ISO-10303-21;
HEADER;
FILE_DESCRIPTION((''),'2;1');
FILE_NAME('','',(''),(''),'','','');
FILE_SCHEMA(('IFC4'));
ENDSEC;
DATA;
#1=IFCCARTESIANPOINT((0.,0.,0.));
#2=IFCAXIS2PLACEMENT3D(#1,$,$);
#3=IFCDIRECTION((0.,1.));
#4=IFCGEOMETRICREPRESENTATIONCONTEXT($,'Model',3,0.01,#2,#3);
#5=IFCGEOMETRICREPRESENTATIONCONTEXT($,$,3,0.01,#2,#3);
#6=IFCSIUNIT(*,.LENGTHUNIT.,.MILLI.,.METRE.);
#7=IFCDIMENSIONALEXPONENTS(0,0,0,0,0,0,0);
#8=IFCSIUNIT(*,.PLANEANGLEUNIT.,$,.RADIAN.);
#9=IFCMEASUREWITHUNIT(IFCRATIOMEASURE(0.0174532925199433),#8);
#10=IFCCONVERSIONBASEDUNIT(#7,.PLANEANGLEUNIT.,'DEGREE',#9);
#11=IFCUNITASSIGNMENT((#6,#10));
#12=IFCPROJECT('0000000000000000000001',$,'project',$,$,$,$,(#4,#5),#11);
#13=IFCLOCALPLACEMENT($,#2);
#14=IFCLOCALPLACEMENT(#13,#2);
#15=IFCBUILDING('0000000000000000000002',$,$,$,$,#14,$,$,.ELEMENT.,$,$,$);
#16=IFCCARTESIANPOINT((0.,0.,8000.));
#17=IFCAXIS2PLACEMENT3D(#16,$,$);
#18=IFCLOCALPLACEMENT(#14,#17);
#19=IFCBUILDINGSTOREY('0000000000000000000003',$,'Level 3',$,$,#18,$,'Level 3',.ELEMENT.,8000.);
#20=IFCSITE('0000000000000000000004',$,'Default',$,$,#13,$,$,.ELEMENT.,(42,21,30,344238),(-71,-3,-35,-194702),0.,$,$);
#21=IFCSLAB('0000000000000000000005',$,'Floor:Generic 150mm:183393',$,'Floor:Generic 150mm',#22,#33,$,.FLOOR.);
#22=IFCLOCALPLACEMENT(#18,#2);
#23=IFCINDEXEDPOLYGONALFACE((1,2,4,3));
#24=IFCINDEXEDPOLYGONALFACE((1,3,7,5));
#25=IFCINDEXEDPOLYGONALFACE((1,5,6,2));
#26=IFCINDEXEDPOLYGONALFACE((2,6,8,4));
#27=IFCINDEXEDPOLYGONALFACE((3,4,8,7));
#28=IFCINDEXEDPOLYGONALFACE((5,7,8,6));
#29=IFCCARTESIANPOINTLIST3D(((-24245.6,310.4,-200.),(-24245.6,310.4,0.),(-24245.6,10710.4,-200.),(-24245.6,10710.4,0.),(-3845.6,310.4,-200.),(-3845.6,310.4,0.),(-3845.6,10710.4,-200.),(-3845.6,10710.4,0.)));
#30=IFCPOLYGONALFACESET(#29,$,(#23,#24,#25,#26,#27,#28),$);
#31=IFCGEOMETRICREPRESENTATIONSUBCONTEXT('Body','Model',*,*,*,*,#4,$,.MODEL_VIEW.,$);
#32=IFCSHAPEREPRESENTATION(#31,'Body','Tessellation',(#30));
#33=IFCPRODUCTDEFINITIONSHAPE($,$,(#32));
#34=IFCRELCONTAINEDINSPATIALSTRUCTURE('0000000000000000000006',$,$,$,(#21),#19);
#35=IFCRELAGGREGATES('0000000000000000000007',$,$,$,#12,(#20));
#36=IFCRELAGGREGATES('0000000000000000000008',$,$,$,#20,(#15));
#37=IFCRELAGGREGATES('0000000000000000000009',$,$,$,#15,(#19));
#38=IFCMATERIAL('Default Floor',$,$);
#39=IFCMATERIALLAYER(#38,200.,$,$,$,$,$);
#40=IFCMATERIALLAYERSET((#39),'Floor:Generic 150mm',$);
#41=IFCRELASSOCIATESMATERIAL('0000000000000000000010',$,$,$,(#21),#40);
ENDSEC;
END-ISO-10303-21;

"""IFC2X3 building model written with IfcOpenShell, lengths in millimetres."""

from ifc_helpers import new_model, entity, si_unit, converted_unit, direction, frame, frame_2d, origin, place, context, subcontext, project, spatial, rectangle, extrude, material, layer, layer_set, layer_usage, element, save


model = new_model("IFC2X3")

# Units and contexts
model_context = context("Model", 3, precision=0.01, world=origin(), true_north=direction((0.0, 1.0)))
context_of_model = context(None, 3, precision=0.01, world=origin(), true_north=direction((0.0, 1.0)))
body_context = subcontext(model_context, "Body", "Model", "MODEL_VIEW")
ifc_project = project(units=[si_unit("LENGTHUNIT", "METRE", prefix="MILLI"), converted_unit("PLANEANGLEUNIT", "DEGREE", entity("IfcRatioMeasure", 0.0174532925199433), si_unit("PLANEANGLEUNIT", "RADIAN"), dimensions=[0, 0, 0, 0, 0, 0, 0])], contexts=[model_context, context_of_model])

# Site, building, storey
site_placement = place(None, origin())
site = spatial("IfcSite", under=ifc_project, at=site_placement, Name="Default", CompositionType="ELEMENT", RefLatitude=(42, 21, 30, 344238), RefLongitude=(-71, -3, -35, -194702), RefElevation=0.0)
building_placement = place(site_placement, origin())
building = spatial("IfcBuilding", under=site, at=building_placement, CompositionType="ELEMENT")
storey_placement = place(building_placement, frame((0.0, 0.0, 8000.0)))
storey = spatial("IfcBuildingStorey", under=building, at=storey_placement, Name="Level 3", LongName="Level 3", CompositionType="ELEMENT", Elevation=8000.0)

# Slab
ifc_material = material(Name="Default Floor")
ifc_layer = layer(ifc_material, 200.0)
ifc_layer_set = layer_set([ifc_layer], Name="Floor:Generic 150mm")
ifc_layer_usage = layer_usage(ifc_layer_set, "AXIS3", "POSITIVE", 0.0)
slab_placement = place(storey_placement, origin())
element("IfcSlab", 1, at=slab_placement, inside=storey, material=ifc_layer_usage, Name="Floor:Generic 150mm:183393", ObjectType="Floor:Generic 150mm", PredefinedType="FLOOR", context=body_context, shape_type="SweptSolid", body=[
    extrude(rectangle(XDim=10400.0, YDim=20400.0, at=frame_2d((0.0, 0.0), x_axis=(1.0, 0.0))), frame((-14045.6, 5510.4, 0.0), z_axis=(0.0, 0.0, -1.0), x_axis=(0.0, 1.0, 0.0)), (0.0, 0.0, 1.0), 200.0),
])

save(model, "model.ifc")
